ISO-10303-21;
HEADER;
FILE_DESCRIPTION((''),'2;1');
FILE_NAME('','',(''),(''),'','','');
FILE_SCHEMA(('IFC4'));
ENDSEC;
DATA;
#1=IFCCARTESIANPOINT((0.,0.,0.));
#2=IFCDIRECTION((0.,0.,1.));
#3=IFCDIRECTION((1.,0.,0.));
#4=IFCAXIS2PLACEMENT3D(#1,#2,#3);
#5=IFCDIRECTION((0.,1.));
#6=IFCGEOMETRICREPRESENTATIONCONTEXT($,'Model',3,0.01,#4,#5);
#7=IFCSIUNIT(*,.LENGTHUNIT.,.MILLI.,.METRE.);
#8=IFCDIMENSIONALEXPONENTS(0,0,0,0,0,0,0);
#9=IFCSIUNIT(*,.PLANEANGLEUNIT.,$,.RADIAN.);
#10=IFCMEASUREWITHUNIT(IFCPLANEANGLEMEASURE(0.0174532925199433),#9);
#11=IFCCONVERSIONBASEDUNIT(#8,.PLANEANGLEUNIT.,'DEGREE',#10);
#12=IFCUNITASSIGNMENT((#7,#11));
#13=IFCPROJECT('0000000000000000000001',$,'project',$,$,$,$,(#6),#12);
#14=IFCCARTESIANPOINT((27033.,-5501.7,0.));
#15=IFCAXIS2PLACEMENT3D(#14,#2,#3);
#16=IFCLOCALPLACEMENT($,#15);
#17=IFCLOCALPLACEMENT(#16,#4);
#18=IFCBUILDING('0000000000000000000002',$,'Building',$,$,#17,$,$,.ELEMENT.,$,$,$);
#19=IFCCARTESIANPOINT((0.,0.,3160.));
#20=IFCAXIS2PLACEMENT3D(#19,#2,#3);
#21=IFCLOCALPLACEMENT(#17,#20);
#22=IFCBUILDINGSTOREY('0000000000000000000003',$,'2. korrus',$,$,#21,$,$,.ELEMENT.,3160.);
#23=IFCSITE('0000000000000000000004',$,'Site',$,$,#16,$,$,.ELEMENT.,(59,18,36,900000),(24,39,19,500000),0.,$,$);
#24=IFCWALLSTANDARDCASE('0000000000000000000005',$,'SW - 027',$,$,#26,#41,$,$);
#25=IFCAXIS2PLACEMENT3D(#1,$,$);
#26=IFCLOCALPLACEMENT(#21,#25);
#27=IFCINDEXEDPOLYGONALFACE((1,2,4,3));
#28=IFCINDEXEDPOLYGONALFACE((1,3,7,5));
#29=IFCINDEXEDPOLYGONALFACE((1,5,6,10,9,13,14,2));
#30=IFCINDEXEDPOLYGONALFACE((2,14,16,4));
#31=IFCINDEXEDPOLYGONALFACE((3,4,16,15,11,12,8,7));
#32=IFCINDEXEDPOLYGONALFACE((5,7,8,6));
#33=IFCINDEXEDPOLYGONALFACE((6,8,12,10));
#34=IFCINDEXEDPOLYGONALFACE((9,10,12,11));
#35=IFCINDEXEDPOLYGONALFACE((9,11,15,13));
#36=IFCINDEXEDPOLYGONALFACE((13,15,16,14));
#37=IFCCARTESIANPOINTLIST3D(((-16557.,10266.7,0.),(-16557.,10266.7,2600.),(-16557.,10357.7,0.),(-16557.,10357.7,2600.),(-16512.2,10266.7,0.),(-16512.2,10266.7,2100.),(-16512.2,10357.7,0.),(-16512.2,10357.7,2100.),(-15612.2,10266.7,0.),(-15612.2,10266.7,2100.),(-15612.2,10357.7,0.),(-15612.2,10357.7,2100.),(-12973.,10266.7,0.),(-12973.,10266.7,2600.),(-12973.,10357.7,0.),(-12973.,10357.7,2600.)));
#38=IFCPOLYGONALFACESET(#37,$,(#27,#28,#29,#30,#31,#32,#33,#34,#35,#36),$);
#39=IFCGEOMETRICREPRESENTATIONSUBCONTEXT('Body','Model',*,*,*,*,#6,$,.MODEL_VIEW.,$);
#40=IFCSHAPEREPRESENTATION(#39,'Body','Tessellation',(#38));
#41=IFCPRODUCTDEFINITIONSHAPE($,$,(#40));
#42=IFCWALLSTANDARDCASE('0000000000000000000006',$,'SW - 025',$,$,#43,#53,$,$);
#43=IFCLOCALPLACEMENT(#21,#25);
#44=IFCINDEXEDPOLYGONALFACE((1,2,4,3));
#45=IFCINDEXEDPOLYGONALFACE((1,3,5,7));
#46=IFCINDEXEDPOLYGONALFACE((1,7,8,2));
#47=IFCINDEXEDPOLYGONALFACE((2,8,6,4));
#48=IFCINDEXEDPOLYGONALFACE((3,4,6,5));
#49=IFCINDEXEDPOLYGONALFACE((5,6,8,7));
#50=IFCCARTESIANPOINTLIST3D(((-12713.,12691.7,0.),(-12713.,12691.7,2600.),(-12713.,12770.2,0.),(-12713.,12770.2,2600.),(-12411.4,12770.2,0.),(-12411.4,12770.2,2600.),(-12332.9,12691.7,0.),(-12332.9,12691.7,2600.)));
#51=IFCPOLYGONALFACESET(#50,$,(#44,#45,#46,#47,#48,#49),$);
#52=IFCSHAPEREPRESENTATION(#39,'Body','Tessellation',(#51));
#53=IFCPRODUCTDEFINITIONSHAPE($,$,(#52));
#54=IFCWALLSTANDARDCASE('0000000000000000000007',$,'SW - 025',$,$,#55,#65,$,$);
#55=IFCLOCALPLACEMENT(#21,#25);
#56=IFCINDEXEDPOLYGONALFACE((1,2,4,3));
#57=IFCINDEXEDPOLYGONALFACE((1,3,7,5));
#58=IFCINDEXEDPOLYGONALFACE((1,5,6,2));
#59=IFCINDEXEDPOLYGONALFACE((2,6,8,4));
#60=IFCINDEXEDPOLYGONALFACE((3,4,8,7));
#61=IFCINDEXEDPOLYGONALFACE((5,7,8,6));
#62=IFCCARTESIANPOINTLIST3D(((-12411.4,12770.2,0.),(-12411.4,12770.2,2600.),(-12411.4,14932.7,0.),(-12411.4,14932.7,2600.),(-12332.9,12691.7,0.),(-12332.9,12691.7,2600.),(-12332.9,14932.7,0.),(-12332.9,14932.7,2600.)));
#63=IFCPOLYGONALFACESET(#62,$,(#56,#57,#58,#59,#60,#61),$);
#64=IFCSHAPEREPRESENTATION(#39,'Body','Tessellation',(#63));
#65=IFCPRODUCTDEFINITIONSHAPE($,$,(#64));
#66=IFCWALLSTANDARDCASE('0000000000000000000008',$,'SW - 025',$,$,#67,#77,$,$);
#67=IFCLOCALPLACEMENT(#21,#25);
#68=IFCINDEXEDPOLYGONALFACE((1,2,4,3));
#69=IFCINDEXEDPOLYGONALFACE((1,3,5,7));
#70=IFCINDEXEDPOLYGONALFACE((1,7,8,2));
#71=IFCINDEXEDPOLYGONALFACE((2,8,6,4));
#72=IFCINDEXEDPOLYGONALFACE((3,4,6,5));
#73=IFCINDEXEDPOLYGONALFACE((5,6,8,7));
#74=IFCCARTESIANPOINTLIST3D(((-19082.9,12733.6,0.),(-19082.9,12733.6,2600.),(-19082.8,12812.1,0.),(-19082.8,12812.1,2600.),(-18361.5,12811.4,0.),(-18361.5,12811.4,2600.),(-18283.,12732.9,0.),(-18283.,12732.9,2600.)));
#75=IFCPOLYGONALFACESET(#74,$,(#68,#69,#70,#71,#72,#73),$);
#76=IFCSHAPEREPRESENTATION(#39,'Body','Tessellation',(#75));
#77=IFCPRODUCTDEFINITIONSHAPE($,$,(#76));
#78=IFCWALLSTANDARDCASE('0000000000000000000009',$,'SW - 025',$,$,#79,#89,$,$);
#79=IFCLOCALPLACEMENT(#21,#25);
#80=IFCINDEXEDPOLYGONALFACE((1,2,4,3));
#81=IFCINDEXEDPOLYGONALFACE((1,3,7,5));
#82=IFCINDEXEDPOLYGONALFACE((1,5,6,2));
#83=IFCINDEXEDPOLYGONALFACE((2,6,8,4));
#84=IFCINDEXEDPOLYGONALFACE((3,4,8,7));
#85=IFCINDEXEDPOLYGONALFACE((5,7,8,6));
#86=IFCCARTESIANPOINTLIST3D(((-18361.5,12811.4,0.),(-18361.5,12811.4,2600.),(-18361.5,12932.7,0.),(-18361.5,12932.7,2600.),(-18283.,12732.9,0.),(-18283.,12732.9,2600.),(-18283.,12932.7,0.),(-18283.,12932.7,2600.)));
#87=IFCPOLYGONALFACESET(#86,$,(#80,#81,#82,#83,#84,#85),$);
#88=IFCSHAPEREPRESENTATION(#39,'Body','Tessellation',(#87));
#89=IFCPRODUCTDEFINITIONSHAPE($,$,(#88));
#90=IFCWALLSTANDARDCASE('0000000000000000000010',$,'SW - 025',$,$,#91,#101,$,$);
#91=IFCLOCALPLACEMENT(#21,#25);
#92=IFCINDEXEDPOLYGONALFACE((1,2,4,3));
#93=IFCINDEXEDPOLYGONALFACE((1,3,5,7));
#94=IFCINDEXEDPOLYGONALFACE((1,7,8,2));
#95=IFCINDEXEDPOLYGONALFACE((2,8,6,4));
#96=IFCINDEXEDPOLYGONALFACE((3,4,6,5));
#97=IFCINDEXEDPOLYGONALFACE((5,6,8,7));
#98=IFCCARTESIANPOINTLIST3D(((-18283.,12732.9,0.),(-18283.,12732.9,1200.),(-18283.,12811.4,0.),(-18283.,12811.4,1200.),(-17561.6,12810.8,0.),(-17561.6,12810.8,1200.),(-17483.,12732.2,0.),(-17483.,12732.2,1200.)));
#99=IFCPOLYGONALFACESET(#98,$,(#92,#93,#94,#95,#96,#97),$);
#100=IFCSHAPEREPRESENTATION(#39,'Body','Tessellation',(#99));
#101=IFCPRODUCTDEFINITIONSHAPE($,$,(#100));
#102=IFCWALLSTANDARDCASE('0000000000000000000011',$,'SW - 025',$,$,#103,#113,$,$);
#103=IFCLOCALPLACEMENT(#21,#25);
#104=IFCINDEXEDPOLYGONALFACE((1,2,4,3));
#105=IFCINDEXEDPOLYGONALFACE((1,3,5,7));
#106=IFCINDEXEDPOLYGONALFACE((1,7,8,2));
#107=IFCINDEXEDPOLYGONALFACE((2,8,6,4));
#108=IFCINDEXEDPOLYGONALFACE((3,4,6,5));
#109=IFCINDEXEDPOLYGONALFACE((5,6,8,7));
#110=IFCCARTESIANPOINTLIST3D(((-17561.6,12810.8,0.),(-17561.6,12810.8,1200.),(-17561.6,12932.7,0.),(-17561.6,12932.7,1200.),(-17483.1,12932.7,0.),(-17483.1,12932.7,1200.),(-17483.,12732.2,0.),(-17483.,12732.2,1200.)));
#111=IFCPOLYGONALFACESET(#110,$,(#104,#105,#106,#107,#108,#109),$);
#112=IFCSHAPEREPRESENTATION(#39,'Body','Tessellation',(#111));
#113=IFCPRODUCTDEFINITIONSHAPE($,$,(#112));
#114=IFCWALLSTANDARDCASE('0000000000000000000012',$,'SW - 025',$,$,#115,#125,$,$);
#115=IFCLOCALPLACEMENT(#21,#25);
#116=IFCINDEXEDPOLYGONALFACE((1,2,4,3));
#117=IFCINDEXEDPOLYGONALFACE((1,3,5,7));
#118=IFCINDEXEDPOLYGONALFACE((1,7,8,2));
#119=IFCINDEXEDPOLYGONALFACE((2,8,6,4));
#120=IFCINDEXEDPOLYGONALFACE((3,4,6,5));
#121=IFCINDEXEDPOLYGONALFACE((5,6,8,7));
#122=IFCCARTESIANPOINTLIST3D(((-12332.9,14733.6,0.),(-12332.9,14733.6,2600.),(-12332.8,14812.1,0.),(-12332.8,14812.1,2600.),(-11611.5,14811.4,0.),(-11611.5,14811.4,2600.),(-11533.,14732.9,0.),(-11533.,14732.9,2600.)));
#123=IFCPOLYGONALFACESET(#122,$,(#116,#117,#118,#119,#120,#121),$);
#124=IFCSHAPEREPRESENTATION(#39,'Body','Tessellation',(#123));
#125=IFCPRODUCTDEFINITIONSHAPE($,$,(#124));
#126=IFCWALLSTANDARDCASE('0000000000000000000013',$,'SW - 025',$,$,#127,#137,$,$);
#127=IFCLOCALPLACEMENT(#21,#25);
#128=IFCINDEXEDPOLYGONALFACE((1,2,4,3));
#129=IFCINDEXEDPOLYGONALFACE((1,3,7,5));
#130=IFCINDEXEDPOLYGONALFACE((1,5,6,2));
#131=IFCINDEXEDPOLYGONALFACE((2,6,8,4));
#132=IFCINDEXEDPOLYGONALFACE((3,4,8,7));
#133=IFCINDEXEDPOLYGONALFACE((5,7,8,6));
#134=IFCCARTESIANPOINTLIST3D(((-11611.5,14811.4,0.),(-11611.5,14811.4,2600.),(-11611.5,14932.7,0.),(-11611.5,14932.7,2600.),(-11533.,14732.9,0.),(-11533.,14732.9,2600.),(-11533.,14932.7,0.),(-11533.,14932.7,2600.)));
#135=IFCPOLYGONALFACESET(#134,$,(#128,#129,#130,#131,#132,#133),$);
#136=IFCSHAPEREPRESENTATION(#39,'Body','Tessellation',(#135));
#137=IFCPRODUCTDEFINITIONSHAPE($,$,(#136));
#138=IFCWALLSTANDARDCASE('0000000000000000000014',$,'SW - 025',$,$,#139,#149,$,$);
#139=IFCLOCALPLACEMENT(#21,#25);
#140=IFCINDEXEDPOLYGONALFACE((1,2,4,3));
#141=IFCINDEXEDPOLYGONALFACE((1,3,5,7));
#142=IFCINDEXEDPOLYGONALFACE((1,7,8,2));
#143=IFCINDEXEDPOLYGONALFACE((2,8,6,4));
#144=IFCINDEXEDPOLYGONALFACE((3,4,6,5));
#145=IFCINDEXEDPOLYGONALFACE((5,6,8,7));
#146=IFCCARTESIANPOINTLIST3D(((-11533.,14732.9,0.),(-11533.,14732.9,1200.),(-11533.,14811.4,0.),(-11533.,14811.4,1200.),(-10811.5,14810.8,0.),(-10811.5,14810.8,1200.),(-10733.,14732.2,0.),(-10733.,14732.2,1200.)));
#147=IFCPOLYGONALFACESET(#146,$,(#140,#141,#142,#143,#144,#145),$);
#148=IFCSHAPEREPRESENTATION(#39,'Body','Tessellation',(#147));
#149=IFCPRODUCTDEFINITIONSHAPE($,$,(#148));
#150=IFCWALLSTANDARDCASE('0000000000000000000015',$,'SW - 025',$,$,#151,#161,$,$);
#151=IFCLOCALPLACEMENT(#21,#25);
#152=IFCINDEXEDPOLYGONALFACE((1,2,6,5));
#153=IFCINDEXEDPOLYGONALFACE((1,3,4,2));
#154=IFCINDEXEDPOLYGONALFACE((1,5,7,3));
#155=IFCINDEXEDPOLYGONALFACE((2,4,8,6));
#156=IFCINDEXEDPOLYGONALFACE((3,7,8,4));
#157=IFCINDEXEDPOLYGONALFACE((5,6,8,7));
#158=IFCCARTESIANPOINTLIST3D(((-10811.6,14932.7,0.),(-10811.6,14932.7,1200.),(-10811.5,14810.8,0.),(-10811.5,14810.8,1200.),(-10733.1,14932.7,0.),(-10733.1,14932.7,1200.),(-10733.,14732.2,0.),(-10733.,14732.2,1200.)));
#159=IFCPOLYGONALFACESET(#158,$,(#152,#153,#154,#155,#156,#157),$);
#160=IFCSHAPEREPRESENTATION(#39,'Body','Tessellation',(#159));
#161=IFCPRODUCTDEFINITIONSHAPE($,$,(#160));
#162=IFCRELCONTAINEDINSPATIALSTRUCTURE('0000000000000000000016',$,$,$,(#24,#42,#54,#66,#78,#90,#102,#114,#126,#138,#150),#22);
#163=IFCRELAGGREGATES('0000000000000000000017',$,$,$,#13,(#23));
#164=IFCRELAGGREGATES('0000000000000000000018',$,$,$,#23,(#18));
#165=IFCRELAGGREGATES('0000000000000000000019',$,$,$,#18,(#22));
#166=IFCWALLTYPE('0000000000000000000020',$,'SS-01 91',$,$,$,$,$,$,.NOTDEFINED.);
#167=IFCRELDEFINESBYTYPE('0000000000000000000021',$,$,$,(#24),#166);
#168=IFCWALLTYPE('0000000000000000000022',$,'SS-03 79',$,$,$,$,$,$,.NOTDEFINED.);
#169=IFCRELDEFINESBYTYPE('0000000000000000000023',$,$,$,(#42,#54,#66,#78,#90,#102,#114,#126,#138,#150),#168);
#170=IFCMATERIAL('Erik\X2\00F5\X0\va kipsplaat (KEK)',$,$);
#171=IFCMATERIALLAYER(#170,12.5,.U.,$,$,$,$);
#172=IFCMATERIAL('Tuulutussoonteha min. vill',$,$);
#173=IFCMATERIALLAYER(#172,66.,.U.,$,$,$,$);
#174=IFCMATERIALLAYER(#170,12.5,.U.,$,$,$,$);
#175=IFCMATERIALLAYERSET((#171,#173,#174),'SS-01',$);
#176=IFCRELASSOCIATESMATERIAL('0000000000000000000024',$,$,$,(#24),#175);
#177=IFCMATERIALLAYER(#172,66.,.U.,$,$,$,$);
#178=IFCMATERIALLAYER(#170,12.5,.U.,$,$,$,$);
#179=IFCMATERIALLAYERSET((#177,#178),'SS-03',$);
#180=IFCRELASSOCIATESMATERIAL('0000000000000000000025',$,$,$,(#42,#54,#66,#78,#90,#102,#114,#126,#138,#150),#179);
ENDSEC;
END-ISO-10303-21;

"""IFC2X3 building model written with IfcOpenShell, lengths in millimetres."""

from ifc_helpers import new_model, entity, si_unit, converted_unit, direction, frame, origin_with_axes, origin_2d_with_axis, place, context, subcontext, project, spatial, polyline, rectangle, outline, extrude, material, layer, layer_set, layer_usage, type_object, element, save


model = new_model("IFC2X3")

# Units and contexts
model_context = context("Model", 3, precision=0.01, world=origin_with_axes(), true_north=direction((0.0, 1.0)))
body_context = subcontext(model_context, "Body", "Model", "MODEL_VIEW")
ifc_project = project(units=[si_unit("LENGTHUNIT", "METRE", prefix="MILLI"), converted_unit("PLANEANGLEUNIT", "DEGREE", entity("IfcPlaneAngleMeasure", 0.0174532925199433), si_unit("PLANEANGLEUNIT", "RADIAN"), dimensions=[0, 0, 0, 0, 0, 0, 0])], contexts=[model_context])

# Site, building, storey
site_placement = place(None, frame((27033.0, -5501.7, 0.0), z_axis=(0.0, 0.0, 1.0), x_axis=(1.0, 0.0, 0.0)))
site = spatial("IfcSite", under=ifc_project, at=site_placement, Name="Site", CompositionType="ELEMENT", RefLatitude=(59, 18, 36, 900000), RefLongitude=(24, 39, 19, 500000), RefElevation=0.0)
building_placement = place(site_placement, origin_with_axes())
building = spatial("IfcBuilding", under=site, at=building_placement, Name="Building", CompositionType="ELEMENT")
storey_placement = place(building_placement, frame((0.0, 0.0, 3160.0), z_axis=(0.0, 0.0, 1.0), x_axis=(1.0, 0.0, 0.0)))
storey = spatial("IfcBuildingStorey", under=building, at=storey_placement, Name="2. korrus", CompositionType="ELEMENT", Elevation=3160.0)

# Shared definitions
ifc_material_1 = material(Name="Erikõva kipsplaat (KEK)")
ifc_layer_1 = layer(ifc_material_1, 12.5, ventilated="UNKNOWN")
ifc_material_2 = material(Name="Tuulutussoonteha min. vill")
ifc_layer_2 = layer(ifc_material_2, 66.0, ventilated="UNKNOWN")
ifc_layer_3 = layer(ifc_material_1, 12.5, ventilated="UNKNOWN")
ifc_layer_set_1 = layer_set([ifc_layer_1, ifc_layer_2, ifc_layer_3], Name="SS-01")
wall_type_1 = type_object("IfcWallType", Name="SS-01 91", PredefinedType="NOTDEFINED")

# Wall, opening
ifc_layer_usage_1 = layer_usage(ifc_layer_set_1, "AXIS2", "POSITIVE", -91.0)
wall_1_placement = place(storey_placement, frame((-16557.0, 10357.7, 0.0), z_axis=(0.0, 0.0, 1.0), x_axis=(1.0, 0.0, 0.0)))
wall_1 = element("IfcWallStandardCase", 1, at=wall_1_placement, inside=storey, type_object=wall_type_1, material=ifc_layer_usage_1, Name="SW - 027", context=body_context, shape_type="SweptSolid", body=[
    extrude(outline(polyline([(0.0, -91.0), (3584.0, -91.0), (3584.0, 0.0), (0.0, 0.0), (0.0, -91.0)])), origin_with_axes(), (0.0, 0.0, 1.0), 2600.0),
])
opening_1_placement = place(wall_1_placement, frame((494.8, 0.0, 0.0), z_axis=(0.0, 0.0, 1.0), x_axis=(1.0, 0.0, 0.0)))
element("IfcOpeningElement", 2, at=opening_1_placement, cuts=wall_1, context=body_context, shape_type="SweptSolid", body=[
    extrude(rectangle(XDim=900.0, YDim=2100.0, at=origin_2d_with_axis()), frame((0.0, 91.0, 1050.0), z_axis=(0.0, -1.0, 0.0), x_axis=(-1.0, 0.0, 0.0)), (0.0, 0.0, 1.0), 273.0),
    extrude(rectangle(XDim=974.0, YDim=2137.0, at=origin_2d_with_axis()), frame((0.0, -91.0, 1068.5), z_axis=(0.0, 1.0, 0.0), x_axis=(-1.0, 0.0, 0.0)), (0.0, 0.0, -1.0), 91.0),
])

# Walls
ifc_layer_4 = layer(ifc_material_2, 66.0, ventilated="UNKNOWN")
ifc_layer_5 = layer(ifc_material_1, 12.5, ventilated="UNKNOWN")
ifc_layer_set_2 = layer_set([ifc_layer_4, ifc_layer_5], Name="SS-03")
ifc_layer_usage_2 = layer_usage(ifc_layer_set_2, "AXIS2", "NEGATIVE", 78.5)
wall_type_2 = type_object("IfcWallType", Name="SS-03 79", PredefinedType="NOTDEFINED")
wall_2_placement = place(storey_placement, frame((-12713.0, 12691.7, 0.0), z_axis=(0.0, 0.0, 1.0), x_axis=(1.0, 0.0, 0.0)))
element("IfcWallStandardCase", 3, at=wall_2_placement, inside=storey, type_object=wall_type_2, material=ifc_layer_usage_2, Name="SW - 025", context=body_context, shape_type="SweptSolid", body=[
    extrude(outline(polyline([(0.0, 0.0), (380.0, 0.0), (301.5, 78.5), (0.0, 78.5), (0.0, 0.0)])), origin_with_axes(), (0.0, 0.0, 1.0), 2600.0),
])
ifc_layer_usage_3 = layer_usage(ifc_layer_set_2, "AXIS2", "NEGATIVE", 78.5)
wall_3_placement = place(storey_placement, frame((-12332.9, 12691.7, 0.0), z_axis=(0.0, 0.0, 1.0), x_axis=(0.0, 1.0, 0.0)))
element("IfcWallStandardCase", 4, at=wall_3_placement, inside=storey, type_object=wall_type_2, material=ifc_layer_usage_3, Name="SW - 025", context=body_context, shape_type="SweptSolid", body=[
    extrude(outline(polyline([(0.0, 0.0), (2241.0, 0.0), (2241.0, 78.5), (78.5, 78.5), (0.0, 0.0)])), origin_with_axes(), (0.0, 0.0, 1.0), 2600.0),
])
ifc_layer_usage_4 = layer_usage(ifc_layer_set_2, "AXIS2", "NEGATIVE", 78.5)
wall_4_placement = place(storey_placement, frame((-19082.9, 12733.6, 0.0), z_axis=(0.0, 0.0, 1.0), x_axis=(1.0, -0.000859, 0.0)))
element("IfcWallStandardCase", 5, at=wall_4_placement, inside=storey, type_object=wall_type_2, material=ifc_layer_usage_4, Name="SW - 025", context=body_context, shape_type="SweptSolid", body=[
    extrude(outline(polyline([(0.0, 0.0), (799.9, 0.0), (721.3, 78.5), (0.0, 78.5), (0.0, 0.0)])), origin_with_axes(), (0.0, 0.0, 1.0), 2600.0),
])
ifc_layer_usage_5 = layer_usage(ifc_layer_set_2, "AXIS2", "NEGATIVE", 78.5)
wall_5_placement = place(storey_placement, frame((-18283.0, 12732.9, 0.0), z_axis=(0.0, 0.0, 1.0), x_axis=(0.0, 1.0, 0.0)))
element("IfcWallStandardCase", 6, at=wall_5_placement, inside=storey, type_object=wall_type_2, material=ifc_layer_usage_5, Name="SW - 025", context=body_context, shape_type="SweptSolid", body=[
    extrude(outline(polyline([(0.0, 0.0), (199.8, 0.0), (199.8, 78.5), (78.6, 78.5), (0.0, 0.0)])), origin_with_axes(), (0.0, 0.0, 1.0), 2600.0),
])
ifc_layer_usage_6 = layer_usage(ifc_layer_set_2, "AXIS2", "NEGATIVE", 78.5)
wall_6_placement = place(storey_placement, frame((-18283.0, 12732.9, 0.0), z_axis=(0.0, 0.0, 1.0), x_axis=(1.0, -0.000859, 0.0)))
element("IfcWallStandardCase", 7, at=wall_6_placement, inside=storey, type_object=wall_type_2, material=ifc_layer_usage_6, Name="SW - 025", context=body_context, shape_type="SweptSolid", body=[
    extrude(outline(polyline([(0.0, 0.0), (800.0, 0.0), (721.4, 78.5), (-0.1, 78.5), (0.0, 0.0)])), origin_with_axes(), (0.0, 0.0, 1.0), 1200.0),
])
ifc_layer_usage_7 = layer_usage(ifc_layer_set_2, "AXIS2", "NEGATIVE", 78.5)
wall_7_placement = place(storey_placement, frame((-17483.0, 12732.2, 0.0), z_axis=(0.0, 0.0, 1.0), x_axis=(-0.000638, 1.0, 0.0)))
element("IfcWallStandardCase", 8, at=wall_7_placement, inside=storey, type_object=wall_type_2, material=ifc_layer_usage_7, Name="SW - 025", context=body_context, shape_type="SweptSolid", body=[
    extrude(outline(polyline([(0.0, 0.0), (200.5, 0.0), (200.5, 78.5), (78.6, 78.5), (0.0, 0.0)])), origin_with_axes(), (0.0, 0.0, 1.0), 1200.0),
])
ifc_layer_usage_8 = layer_usage(ifc_layer_set_2, "AXIS2", "NEGATIVE", 78.5)
wall_8_placement = place(storey_placement, frame((-12332.9, 14733.6, 0.0), z_axis=(0.0, 0.0, 1.0), x_axis=(1.0, -0.000859, 0.0)))
element("IfcWallStandardCase", 9, at=wall_8_placement, inside=storey, type_object=wall_type_2, material=ifc_layer_usage_8, Name="SW - 025", context=body_context, shape_type="SweptSolid", body=[
    extrude(outline(polyline([(0.0, 0.0), (799.9, 0.0), (721.3, 78.5), (0.0, 78.5), (0.0, 0.0)])), origin_with_axes(), (0.0, 0.0, 1.0), 2600.0),
])
ifc_layer_usage_9 = layer_usage(ifc_layer_set_2, "AXIS2", "NEGATIVE", 78.5)
wall_9_placement = place(storey_placement, frame((-11533.0, 14732.9, 0.0), z_axis=(0.0, 0.0, 1.0), x_axis=(0.0, 1.0, 0.0)))
element("IfcWallStandardCase", 10, at=wall_9_placement, inside=storey, type_object=wall_type_2, material=ifc_layer_usage_9, Name="SW - 025", context=body_context, shape_type="SweptSolid", body=[
    extrude(outline(polyline([(0.0, 0.0), (199.8, 0.0), (199.8, 78.5), (78.6, 78.5), (0.0, 0.0)])), origin_with_axes(), (0.0, 0.0, 1.0), 2600.0),
])
ifc_layer_usage_10 = layer_usage(ifc_layer_set_2, "AXIS2", "NEGATIVE", 78.5)
wall_10_placement = place(storey_placement, frame((-11533.0, 14732.9, 0.0), z_axis=(0.0, 0.0, 1.0), x_axis=(1.0, -0.000859, 0.0)))
element("IfcWallStandardCase", 11, at=wall_10_placement, inside=storey, type_object=wall_type_2, material=ifc_layer_usage_10, Name="SW - 025", context=body_context, shape_type="SweptSolid", body=[
    extrude(outline(polyline([(0.0, 0.0), (800.0, 0.0), (721.4, 78.5), (-0.1, 78.5), (0.0, 0.0)])), origin_with_axes(), (0.0, 0.0, 1.0), 1200.0),
])
ifc_layer_usage_11 = layer_usage(ifc_layer_set_2, "AXIS2", "NEGATIVE", 78.5)
wall_11_placement = place(storey_placement, frame((-10733.0, 14732.2, 0.0), z_axis=(0.0, 0.0, 1.0), x_axis=(-0.000638, 1.0, 0.0)))
element("IfcWallStandardCase", 12, at=wall_11_placement, inside=storey, type_object=wall_type_2, material=ifc_layer_usage_11, Name="SW - 025", context=body_context, shape_type="SweptSolid", body=[
    extrude(outline(polyline([(0.0, 0.0), (200.5, 0.0), (200.5, 78.5), (78.6, 78.5), (0.0, 0.0)])), origin_with_axes(), (0.0, 0.0, 1.0), 1200.0),
])

save(model, "model.ifc")
